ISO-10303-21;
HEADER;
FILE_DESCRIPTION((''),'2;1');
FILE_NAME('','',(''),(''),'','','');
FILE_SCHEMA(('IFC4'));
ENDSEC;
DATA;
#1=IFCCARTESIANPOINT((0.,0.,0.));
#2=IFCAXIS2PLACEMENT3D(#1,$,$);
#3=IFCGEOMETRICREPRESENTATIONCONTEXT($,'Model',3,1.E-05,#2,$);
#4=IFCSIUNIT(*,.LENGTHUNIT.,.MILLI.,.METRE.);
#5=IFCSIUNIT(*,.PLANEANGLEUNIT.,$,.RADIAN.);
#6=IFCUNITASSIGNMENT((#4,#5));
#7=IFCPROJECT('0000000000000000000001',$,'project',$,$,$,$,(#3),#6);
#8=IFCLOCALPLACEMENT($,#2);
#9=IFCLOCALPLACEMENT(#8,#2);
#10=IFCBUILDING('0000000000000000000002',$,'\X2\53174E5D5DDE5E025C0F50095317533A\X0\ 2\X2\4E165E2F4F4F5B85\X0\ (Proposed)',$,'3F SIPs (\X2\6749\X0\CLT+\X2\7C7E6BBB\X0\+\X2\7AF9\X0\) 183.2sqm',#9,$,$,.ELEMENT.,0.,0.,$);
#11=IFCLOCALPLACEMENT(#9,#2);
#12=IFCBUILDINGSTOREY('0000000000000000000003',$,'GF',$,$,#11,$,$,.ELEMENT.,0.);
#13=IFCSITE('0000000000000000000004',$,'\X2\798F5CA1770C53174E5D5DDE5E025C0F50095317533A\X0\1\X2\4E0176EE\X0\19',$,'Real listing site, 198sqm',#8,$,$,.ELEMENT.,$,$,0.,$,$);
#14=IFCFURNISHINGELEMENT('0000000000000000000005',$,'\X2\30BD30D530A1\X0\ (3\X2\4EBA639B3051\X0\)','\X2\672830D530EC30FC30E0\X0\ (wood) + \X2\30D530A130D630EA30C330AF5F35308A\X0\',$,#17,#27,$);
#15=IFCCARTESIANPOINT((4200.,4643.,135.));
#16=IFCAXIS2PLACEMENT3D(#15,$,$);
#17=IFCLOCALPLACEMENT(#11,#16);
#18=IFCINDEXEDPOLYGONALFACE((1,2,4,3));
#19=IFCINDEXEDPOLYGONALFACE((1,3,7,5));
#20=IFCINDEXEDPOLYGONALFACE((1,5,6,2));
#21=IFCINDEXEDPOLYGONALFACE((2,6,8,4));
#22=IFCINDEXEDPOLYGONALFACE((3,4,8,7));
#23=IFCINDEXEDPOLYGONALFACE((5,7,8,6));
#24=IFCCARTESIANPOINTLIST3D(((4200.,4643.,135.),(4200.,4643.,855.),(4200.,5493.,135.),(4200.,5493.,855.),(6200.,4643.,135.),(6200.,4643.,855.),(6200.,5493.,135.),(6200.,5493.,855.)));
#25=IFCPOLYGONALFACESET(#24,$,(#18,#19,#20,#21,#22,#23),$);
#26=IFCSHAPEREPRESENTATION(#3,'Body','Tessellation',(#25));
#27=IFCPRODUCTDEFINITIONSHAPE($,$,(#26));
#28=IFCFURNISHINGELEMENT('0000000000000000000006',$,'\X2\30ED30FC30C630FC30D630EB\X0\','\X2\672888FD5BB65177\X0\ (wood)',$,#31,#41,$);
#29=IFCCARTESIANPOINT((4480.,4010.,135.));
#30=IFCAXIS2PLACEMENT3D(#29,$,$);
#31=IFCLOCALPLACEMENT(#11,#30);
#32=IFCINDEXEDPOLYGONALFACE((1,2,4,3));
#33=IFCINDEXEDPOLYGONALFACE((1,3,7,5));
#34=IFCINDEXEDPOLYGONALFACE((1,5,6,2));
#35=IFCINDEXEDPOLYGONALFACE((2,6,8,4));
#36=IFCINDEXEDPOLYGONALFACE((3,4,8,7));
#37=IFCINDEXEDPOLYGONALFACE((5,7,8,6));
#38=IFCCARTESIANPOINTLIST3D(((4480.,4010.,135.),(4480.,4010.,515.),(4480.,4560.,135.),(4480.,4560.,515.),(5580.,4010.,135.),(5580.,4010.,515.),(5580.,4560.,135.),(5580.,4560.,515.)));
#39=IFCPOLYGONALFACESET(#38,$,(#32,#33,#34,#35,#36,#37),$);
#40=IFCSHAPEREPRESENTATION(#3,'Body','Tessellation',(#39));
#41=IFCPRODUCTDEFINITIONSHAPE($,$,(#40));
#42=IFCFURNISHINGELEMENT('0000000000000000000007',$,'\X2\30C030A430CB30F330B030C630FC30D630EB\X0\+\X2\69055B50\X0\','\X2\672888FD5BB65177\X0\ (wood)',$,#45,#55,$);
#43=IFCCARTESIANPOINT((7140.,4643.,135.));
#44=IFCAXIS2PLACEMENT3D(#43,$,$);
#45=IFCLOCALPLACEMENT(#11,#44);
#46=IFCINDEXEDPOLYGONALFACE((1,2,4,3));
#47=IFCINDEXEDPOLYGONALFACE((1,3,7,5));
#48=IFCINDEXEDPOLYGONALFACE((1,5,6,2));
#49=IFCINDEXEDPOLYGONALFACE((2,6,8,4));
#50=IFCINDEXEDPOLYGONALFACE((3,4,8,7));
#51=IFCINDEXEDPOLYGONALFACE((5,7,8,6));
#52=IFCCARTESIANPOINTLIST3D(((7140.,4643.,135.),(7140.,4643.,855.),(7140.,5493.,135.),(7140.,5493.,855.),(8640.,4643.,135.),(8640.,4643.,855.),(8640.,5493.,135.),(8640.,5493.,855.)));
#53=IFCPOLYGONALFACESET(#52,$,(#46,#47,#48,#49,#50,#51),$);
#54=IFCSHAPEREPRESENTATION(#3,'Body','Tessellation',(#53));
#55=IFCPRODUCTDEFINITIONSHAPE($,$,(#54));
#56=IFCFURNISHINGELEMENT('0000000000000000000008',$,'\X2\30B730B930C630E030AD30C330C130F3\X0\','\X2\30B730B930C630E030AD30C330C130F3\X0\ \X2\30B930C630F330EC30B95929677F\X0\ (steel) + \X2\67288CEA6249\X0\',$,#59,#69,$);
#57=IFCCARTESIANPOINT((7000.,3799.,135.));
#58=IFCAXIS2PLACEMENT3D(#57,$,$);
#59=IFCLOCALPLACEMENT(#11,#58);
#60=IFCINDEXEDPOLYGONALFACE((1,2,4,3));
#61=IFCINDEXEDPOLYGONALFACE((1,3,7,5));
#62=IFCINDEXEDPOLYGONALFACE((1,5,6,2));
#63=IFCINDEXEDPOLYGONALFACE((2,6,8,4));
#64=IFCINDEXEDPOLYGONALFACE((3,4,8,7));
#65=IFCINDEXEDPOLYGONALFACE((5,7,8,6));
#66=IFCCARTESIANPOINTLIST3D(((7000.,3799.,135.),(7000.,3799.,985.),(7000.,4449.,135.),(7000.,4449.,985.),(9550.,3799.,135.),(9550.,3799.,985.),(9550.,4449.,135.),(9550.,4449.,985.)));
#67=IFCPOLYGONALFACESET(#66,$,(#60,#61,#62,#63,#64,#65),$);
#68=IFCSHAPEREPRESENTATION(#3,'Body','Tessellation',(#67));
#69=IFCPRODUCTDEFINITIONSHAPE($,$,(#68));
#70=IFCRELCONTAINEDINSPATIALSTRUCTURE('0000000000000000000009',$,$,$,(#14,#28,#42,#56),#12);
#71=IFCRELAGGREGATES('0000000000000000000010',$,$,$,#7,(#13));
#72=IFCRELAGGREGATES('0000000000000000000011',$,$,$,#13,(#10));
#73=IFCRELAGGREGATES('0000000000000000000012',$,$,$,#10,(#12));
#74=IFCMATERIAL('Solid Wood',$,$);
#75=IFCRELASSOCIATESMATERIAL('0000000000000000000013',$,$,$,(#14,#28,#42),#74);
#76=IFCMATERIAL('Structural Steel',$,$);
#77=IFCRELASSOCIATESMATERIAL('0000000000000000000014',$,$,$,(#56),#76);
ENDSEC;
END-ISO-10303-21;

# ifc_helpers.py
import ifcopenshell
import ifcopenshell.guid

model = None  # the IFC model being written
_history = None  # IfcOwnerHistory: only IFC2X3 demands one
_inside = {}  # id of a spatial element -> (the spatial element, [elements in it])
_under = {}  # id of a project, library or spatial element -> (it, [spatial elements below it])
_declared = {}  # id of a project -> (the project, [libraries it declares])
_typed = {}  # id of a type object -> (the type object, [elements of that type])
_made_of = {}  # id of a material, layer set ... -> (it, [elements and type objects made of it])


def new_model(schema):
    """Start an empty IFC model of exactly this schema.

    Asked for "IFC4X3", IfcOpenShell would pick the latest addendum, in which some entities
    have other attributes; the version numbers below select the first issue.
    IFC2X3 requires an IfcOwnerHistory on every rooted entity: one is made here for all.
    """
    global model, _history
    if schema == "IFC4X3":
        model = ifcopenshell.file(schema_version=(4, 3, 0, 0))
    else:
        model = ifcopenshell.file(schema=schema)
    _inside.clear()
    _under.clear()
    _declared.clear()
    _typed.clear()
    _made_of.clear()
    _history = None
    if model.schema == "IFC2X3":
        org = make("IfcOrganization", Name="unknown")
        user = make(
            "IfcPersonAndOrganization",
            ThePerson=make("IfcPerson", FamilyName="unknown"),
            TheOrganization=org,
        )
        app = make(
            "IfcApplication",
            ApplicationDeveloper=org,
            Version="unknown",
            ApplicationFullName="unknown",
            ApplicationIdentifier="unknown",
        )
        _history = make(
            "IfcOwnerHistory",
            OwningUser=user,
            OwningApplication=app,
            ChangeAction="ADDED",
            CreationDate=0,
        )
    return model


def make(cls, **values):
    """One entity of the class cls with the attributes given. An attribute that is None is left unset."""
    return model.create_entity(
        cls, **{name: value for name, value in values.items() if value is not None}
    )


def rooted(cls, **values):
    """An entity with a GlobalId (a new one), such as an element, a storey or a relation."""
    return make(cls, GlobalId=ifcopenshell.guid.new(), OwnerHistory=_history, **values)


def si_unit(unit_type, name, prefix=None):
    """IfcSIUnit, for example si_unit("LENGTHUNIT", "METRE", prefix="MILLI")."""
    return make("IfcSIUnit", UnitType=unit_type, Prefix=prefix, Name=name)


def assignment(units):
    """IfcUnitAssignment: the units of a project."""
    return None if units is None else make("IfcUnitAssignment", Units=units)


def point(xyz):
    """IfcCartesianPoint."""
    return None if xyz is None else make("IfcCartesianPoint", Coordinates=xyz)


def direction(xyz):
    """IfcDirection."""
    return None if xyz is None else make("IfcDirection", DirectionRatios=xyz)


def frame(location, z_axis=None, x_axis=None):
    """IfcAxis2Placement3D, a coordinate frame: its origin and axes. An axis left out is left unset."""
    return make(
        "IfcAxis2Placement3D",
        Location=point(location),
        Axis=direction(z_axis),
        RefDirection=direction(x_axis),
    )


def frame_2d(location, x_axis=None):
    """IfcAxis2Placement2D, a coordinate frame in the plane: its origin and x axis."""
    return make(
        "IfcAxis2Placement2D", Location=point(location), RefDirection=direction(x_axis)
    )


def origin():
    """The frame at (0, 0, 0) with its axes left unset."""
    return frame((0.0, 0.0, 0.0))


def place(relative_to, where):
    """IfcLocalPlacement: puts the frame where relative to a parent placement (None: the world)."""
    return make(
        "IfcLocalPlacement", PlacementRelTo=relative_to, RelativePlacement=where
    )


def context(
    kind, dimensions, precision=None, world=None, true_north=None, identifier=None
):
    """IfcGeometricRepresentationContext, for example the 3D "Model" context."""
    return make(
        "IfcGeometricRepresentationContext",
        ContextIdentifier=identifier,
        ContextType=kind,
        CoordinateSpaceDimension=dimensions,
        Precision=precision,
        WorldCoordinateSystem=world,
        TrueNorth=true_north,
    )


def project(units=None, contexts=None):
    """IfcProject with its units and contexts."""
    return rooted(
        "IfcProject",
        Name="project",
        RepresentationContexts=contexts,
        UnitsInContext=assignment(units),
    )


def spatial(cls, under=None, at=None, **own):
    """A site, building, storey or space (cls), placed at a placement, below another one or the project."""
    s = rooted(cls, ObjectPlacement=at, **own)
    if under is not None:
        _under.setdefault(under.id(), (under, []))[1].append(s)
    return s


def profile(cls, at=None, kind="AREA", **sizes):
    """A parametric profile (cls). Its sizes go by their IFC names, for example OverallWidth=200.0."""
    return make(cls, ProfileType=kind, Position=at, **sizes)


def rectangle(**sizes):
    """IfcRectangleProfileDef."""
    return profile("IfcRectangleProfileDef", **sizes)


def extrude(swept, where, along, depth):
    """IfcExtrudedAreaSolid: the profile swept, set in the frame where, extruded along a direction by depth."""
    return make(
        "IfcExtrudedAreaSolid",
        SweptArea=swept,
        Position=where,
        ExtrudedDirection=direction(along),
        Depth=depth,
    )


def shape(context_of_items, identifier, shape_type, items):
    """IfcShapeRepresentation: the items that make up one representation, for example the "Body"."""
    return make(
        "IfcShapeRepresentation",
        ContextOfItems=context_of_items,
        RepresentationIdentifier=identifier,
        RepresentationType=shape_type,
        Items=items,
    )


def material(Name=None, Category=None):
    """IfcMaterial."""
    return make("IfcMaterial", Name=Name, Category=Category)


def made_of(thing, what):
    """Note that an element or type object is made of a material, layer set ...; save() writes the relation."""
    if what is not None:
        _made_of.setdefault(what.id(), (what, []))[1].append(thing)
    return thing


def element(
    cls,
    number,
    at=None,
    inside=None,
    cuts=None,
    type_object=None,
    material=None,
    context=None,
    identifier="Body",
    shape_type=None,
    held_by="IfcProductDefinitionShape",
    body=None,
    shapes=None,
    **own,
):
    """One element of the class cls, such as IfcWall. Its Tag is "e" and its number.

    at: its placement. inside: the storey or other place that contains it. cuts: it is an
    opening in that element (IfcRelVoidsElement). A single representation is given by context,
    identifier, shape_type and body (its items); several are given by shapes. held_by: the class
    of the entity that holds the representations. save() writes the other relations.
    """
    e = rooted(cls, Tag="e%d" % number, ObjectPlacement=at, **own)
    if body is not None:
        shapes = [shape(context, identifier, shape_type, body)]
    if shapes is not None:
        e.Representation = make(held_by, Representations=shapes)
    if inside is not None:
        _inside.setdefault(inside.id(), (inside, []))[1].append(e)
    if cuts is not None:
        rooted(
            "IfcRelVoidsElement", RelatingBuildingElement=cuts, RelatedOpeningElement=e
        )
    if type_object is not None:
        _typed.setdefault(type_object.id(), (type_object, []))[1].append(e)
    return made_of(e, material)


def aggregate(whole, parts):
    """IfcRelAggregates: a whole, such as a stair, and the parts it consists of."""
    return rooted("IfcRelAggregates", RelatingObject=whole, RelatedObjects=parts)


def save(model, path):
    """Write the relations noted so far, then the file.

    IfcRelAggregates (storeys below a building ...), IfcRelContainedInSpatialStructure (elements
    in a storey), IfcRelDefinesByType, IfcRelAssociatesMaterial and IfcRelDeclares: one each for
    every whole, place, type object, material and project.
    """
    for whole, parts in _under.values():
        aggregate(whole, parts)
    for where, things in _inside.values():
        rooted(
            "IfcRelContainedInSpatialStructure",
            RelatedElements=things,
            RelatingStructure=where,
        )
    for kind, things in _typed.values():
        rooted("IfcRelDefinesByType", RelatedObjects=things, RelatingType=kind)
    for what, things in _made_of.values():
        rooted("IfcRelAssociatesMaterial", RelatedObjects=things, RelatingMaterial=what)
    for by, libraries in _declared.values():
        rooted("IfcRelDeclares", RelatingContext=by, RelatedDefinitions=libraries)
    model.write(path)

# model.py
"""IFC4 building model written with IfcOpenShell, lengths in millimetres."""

from ifc_helpers import new_model, si_unit, frame, frame_2d, origin, place, context, project, spatial, rectangle, extrude, material, element, save


model = new_model("IFC4")

# Units and contexts
model_context = context("Model", 3, precision=1e-05, world=origin())
ifc_project = project(units=[si_unit("LENGTHUNIT", "METRE", prefix="MILLI"), si_unit("PLANEANGLEUNIT", "RADIAN")], contexts=[model_context])

# Site, building, storey
site_placement = place(None, origin())
site = spatial("IfcSite", under=ifc_project, at=site_placement, Name="福岡県北九州市小倉北区1丁目19", ObjectType="Real listing site, 198sqm", CompositionType="ELEMENT", RefElevation=0.0)
building_placement = place(site_placement, origin())
building = spatial("IfcBuilding", under=site, at=building_placement, Name="北九州市小倉北区 2世帯住宅 (Proposed)", ObjectType="3F SIPs (杉CLT+籾殻+竹) 183.2sqm", CompositionType="ELEMENT", ElevationOfRefHeight=0.0, ElevationOfTerrain=0.0)
storey_placement = place(building_placement, origin())
storey = spatial("IfcBuildingStorey", under=building, at=storey_placement, Name="GF", CompositionType="ELEMENT", Elevation=0.0)

# Shared definitions
ifc_material_1 = material(Name="Solid Wood")

# Furnishing elements
furnishing_1_placement = place(storey_placement, frame((4200.0, 4643.0, 135.0)))
element("IfcFurnishingElement", 1, at=furnishing_1_placement, inside=storey, material=ifc_material_1, Name="ソファ (3人掛け)", Description="木フレーム (wood) + ファブリック張り", context=model_context, shape_type="SweptSolid", body=[
    extrude(rectangle(XDim=2000.0, YDim=850.0, at=frame_2d((1000.0, 425.0))), frame((4200.0, 4643.0, 135.0)), (0.0, 0.0, 1.0), 720.0),
])
furnishing_2_placement = place(storey_placement, frame((4480.0, 4010.0, 135.0)))
element("IfcFurnishingElement", 2, at=furnishing_2_placement, inside=storey, material=ifc_material_1, Name="ローテーブル", Description="木製家具 (wood)", context=model_context, shape_type="SweptSolid", body=[
    extrude(rectangle(XDim=1100.0, YDim=550.0, at=frame_2d((550.0, 275.0))), frame((4480.0, 4010.0, 135.0)), (0.0, 0.0, 1.0), 380.0),
])
furnishing_3_placement = place(storey_placement, frame((7140.0, 4643.0, 135.0)))
element("IfcFurnishingElement", 3, at=furnishing_3_placement, inside=storey, material=ifc_material_1, Name="ダイニングテーブル+椅子", Description="木製家具 (wood)", context=model_context, shape_type="SweptSolid", body=[
    extrude(rectangle(XDim=1500.0, YDim=850.0, at=frame_2d((750.0, 425.0))), frame((7140.0, 4643.0, 135.0)), (0.0, 0.0, 1.0), 720.0),
])
ifc_material_2 = material(Name="Structural Steel")
furnishing_4_placement = place(storey_placement, frame((7000.0, 3799.0, 135.0)))
element("IfcFurnishingElement", 4, at=furnishing_4_placement, inside=storey, material=ifc_material_2, Name="システムキッチン", Description="システムキッチン ステンレス天板 (steel) + 木質扉", context=model_context, shape_type="SweptSolid", body=[
    extrude(rectangle(XDim=2550.0, YDim=650.0, at=frame_2d((1275.0, 325.0))), frame((7000.0, 3799.0, 135.0)), (0.0, 0.0, 1.0), 850.0),
])

save(model, "model.ifc")
